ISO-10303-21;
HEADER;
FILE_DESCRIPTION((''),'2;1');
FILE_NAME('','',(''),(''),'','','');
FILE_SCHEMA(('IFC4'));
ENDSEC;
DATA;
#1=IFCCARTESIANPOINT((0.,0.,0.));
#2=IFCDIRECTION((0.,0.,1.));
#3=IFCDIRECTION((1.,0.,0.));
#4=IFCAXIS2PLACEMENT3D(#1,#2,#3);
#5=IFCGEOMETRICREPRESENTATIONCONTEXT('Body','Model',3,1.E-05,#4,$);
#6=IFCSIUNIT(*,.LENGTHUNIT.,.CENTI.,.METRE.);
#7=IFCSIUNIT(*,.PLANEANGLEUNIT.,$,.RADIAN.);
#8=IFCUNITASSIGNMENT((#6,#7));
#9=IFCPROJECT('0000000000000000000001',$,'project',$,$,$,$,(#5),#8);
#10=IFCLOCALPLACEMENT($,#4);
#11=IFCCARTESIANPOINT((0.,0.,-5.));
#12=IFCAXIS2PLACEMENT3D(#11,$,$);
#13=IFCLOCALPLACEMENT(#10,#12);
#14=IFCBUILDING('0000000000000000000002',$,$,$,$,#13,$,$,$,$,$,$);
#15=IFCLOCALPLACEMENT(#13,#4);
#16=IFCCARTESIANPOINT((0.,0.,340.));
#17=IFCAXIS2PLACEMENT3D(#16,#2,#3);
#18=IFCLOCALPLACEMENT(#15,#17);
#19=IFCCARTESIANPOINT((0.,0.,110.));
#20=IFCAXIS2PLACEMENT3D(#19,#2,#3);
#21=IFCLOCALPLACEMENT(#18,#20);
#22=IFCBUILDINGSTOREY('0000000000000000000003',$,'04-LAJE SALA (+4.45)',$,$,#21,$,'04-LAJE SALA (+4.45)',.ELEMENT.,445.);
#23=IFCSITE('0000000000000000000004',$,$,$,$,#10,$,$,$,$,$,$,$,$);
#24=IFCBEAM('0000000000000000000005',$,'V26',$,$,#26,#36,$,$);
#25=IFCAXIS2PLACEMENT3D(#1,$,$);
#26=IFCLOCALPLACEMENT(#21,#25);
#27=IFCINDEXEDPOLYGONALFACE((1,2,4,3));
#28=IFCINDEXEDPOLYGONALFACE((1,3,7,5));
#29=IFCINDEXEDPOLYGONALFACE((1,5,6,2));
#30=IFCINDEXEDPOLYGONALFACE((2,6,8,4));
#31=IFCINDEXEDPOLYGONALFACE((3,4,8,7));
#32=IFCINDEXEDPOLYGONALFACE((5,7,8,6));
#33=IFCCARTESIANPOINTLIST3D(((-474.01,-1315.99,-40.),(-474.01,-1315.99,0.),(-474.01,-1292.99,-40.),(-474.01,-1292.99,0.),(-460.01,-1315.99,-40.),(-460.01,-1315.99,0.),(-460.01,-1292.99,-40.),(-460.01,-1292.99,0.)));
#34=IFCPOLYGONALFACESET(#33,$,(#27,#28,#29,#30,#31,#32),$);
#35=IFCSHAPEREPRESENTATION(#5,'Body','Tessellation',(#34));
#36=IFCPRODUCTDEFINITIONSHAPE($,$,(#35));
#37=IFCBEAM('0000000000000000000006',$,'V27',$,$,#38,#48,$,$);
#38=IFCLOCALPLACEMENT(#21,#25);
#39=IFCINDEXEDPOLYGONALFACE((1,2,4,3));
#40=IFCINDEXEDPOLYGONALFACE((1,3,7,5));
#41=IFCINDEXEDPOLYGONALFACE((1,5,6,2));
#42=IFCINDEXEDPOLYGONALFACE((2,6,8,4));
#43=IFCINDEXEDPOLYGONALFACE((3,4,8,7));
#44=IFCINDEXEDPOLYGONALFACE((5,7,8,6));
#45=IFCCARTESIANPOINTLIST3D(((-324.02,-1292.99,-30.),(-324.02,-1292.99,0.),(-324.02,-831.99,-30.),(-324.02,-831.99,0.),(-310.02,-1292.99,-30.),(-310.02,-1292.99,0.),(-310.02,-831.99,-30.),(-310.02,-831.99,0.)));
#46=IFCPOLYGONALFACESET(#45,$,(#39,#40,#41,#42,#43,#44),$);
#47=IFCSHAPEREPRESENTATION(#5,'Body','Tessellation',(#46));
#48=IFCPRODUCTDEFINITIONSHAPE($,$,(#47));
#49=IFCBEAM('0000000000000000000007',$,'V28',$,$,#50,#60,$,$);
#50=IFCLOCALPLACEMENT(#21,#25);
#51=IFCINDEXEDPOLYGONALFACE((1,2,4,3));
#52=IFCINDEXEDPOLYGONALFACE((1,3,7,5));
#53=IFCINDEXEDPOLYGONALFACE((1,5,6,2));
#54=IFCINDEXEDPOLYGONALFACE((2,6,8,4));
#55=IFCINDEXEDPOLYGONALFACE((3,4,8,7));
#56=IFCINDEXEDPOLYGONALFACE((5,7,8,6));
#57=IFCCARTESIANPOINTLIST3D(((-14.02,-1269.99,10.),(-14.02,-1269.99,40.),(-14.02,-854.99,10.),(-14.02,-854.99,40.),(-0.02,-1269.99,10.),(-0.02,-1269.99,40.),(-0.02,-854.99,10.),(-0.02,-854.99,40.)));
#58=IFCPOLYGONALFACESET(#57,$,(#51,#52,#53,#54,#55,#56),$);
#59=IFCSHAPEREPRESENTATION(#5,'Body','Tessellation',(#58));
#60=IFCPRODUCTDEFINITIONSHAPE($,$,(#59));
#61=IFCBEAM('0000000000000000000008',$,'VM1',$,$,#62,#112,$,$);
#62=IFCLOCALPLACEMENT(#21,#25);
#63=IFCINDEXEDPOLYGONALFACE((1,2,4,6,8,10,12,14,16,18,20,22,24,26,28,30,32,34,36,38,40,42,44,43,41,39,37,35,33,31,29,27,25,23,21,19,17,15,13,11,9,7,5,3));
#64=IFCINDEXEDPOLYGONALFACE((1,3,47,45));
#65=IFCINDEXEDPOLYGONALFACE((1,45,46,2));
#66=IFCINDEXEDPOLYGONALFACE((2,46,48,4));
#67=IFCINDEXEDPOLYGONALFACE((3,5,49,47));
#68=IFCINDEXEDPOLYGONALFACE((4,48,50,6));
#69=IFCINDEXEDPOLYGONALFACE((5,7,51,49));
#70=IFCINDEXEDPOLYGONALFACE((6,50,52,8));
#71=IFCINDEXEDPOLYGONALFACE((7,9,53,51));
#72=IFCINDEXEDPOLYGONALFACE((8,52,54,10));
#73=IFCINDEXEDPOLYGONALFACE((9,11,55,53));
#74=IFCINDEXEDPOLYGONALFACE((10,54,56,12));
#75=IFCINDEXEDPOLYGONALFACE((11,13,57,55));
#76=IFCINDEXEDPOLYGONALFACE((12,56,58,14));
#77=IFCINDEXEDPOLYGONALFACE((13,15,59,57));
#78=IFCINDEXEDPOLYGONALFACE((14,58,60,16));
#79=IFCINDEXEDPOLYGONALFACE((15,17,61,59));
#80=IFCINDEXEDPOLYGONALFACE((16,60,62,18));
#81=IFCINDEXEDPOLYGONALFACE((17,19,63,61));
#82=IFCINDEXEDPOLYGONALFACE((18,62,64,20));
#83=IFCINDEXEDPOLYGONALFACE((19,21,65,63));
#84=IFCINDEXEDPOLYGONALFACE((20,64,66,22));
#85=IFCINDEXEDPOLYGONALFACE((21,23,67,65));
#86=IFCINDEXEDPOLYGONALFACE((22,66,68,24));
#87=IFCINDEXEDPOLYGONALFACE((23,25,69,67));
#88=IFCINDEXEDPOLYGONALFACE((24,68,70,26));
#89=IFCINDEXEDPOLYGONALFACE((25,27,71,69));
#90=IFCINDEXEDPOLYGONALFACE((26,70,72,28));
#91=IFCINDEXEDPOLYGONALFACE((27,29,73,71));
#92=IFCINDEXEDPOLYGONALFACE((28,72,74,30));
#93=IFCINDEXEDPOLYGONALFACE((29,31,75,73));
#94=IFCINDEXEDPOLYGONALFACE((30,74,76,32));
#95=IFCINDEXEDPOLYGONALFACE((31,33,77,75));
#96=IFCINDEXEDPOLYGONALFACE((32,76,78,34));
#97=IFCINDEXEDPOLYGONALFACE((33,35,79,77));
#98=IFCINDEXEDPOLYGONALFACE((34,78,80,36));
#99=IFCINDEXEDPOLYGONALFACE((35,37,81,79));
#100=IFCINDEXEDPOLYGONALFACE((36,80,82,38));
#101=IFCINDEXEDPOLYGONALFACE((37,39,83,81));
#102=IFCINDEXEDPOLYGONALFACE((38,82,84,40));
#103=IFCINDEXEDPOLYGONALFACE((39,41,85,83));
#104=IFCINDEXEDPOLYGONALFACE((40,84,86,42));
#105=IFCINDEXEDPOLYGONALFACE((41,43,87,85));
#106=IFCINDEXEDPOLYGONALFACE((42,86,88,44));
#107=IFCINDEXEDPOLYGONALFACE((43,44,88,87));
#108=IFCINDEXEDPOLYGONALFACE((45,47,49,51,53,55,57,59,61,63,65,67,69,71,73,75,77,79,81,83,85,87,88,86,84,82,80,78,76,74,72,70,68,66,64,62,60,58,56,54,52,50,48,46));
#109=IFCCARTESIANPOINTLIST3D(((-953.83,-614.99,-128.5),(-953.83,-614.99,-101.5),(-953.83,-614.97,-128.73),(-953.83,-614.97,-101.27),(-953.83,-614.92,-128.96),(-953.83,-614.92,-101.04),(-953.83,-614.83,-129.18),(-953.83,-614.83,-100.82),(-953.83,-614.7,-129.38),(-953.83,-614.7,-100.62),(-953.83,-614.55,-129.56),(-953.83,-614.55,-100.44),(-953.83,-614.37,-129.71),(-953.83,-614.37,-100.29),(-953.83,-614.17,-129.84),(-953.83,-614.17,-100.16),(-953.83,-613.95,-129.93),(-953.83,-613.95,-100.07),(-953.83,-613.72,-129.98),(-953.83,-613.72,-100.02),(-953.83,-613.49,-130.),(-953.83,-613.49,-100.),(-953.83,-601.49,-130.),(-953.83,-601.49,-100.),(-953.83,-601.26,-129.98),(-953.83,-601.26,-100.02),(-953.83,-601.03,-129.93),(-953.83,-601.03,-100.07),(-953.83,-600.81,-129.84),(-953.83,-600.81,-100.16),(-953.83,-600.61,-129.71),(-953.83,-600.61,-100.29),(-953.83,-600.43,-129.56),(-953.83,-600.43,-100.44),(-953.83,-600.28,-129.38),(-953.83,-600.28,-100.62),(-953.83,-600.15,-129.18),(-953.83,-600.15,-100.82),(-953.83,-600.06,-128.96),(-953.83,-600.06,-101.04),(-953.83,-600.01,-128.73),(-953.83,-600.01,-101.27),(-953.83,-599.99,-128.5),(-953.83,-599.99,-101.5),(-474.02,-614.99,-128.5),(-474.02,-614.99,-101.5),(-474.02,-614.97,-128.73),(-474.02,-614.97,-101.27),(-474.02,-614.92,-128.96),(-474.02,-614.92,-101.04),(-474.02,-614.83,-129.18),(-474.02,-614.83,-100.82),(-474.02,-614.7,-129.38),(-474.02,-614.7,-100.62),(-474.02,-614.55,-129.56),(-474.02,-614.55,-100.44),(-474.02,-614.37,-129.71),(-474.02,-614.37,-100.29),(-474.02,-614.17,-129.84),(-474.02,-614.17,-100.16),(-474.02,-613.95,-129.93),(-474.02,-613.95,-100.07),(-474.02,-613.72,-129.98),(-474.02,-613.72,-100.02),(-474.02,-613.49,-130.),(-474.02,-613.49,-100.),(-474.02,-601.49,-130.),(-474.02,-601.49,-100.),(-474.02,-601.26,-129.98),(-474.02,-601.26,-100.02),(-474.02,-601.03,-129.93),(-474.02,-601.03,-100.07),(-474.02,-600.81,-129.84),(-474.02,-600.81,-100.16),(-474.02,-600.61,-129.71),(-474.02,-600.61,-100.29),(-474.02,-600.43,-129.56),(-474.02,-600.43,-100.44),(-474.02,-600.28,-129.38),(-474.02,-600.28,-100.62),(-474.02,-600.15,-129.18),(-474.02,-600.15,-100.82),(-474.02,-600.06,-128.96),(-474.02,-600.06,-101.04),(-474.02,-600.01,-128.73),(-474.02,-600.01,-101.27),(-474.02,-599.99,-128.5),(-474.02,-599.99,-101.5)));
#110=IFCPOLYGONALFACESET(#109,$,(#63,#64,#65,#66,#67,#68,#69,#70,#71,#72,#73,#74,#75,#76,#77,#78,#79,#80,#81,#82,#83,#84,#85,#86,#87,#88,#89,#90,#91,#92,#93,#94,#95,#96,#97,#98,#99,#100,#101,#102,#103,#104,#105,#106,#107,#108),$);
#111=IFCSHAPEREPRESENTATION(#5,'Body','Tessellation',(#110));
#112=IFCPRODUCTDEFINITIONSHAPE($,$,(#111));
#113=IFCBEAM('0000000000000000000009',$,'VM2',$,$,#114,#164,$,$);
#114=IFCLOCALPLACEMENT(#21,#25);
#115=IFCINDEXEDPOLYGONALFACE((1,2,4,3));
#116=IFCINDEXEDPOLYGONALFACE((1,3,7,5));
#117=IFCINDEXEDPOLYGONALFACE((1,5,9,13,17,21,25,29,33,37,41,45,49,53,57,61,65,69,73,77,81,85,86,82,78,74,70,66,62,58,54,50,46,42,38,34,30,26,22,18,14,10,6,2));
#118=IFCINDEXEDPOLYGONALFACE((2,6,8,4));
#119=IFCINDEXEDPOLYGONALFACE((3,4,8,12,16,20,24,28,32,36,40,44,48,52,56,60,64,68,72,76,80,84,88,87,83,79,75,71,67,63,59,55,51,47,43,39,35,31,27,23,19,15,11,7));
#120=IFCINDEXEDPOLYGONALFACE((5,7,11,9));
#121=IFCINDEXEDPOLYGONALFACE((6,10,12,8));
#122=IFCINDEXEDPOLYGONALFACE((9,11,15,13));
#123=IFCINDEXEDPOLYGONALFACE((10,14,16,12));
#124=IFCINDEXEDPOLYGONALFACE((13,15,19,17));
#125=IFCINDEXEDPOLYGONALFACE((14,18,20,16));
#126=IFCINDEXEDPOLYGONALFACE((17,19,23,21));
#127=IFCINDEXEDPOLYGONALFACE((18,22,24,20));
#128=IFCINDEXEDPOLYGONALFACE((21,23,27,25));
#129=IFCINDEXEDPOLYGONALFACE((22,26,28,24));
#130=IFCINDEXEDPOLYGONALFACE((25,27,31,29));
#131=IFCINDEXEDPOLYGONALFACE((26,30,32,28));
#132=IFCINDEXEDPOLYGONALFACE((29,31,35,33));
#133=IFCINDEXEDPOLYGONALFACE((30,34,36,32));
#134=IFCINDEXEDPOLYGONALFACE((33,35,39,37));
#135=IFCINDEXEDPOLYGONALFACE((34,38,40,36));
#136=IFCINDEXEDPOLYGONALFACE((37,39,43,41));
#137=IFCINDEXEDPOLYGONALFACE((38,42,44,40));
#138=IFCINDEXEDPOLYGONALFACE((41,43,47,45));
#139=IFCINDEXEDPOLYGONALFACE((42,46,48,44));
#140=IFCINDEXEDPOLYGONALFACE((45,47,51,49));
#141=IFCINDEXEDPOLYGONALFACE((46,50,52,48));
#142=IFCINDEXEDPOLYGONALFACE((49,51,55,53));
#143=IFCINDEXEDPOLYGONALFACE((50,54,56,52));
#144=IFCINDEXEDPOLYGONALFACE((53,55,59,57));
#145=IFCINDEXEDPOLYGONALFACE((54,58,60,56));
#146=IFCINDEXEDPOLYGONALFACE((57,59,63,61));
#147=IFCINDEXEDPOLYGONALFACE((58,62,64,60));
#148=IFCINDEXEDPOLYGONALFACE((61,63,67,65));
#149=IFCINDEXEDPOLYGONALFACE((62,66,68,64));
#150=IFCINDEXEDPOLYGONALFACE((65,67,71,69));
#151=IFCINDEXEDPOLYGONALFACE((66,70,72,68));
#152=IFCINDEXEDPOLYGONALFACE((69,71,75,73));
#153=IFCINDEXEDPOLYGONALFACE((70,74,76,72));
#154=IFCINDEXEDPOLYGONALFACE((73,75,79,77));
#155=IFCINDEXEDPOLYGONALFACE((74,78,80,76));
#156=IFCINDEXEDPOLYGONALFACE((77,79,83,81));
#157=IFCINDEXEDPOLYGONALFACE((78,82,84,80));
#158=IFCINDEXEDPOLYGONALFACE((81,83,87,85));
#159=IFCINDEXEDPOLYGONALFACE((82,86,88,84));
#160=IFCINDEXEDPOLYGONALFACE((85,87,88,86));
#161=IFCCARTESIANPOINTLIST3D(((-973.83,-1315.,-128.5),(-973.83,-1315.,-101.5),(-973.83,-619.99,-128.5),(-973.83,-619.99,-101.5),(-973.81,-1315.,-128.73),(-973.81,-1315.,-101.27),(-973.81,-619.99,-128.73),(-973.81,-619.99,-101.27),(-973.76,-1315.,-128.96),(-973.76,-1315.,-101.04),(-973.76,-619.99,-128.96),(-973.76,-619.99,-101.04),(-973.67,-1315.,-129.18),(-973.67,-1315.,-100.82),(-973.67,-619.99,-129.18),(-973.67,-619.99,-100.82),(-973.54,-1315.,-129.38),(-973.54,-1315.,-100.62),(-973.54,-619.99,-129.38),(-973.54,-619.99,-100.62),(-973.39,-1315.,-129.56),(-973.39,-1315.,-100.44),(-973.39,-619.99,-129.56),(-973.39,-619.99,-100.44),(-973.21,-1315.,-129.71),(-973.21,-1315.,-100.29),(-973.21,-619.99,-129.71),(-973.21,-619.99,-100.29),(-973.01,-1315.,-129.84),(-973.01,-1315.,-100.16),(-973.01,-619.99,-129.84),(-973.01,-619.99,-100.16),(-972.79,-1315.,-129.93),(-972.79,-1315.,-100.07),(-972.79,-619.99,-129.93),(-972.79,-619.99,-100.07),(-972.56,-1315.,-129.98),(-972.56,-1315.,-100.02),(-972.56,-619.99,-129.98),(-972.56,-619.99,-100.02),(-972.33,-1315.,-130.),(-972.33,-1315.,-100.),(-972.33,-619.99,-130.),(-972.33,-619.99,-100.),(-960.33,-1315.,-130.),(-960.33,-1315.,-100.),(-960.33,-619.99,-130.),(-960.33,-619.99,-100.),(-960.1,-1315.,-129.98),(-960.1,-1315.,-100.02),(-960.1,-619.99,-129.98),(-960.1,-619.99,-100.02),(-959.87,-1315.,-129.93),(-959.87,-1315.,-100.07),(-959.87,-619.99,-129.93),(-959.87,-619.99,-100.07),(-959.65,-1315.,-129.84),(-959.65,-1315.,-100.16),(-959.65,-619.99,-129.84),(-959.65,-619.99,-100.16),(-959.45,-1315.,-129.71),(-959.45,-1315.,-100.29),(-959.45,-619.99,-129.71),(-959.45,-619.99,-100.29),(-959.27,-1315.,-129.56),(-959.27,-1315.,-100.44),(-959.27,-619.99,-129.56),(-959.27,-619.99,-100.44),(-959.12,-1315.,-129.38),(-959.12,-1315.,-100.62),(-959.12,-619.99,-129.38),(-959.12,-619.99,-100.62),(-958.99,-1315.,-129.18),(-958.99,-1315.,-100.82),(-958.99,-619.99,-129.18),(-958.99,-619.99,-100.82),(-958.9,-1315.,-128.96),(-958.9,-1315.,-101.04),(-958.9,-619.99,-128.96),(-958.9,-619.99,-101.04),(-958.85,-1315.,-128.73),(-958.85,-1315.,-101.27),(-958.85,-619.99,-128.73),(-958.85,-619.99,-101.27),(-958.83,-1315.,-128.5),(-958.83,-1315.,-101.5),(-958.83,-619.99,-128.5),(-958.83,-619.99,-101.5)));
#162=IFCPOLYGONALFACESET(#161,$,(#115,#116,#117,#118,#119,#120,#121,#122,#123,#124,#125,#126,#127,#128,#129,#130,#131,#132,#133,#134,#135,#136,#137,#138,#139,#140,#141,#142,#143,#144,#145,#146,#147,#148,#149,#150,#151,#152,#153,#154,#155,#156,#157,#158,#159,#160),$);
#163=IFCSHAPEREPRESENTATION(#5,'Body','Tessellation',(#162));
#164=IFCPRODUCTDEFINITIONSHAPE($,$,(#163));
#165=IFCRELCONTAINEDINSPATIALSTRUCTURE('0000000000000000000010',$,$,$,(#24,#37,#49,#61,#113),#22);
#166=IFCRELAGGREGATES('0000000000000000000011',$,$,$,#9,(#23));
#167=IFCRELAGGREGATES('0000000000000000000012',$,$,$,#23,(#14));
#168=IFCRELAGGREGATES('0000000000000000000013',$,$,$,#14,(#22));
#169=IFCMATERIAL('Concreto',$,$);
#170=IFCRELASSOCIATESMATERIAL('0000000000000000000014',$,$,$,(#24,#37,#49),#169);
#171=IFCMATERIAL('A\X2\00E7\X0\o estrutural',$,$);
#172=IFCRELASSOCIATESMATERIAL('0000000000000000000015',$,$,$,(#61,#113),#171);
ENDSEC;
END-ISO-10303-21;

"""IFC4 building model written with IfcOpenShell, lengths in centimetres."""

from ifc_helpers import new_model, si_unit, frame, origin_with_axes, origin_2d_with_axis, place, context, project, spatial, polyline, rectangle, outline, extrude, material, element, save


model = new_model("IFC4")

# Units and contexts
model_context = context("Model", 3, precision=1e-05, world=origin_with_axes(), identifier="Body")
ifc_project = project(units=[si_unit("LENGTHUNIT", "METRE", prefix="CENTI"), si_unit("PLANEANGLEUNIT", "RADIAN")], contexts=[model_context])

# Site, building, storey
site_placement = place(None, origin_with_axes())
site = spatial("IfcSite", under=ifc_project, at=site_placement)
building_placement = place(site_placement, frame((0.0, 0.0, -5.0)))
building = spatial("IfcBuilding", under=site, at=building_placement)
placement_1 = place(building_placement, origin_with_axes())
placement_2 = place(placement_1, frame((0.0, 0.0, 340.0), z_axis=(0.0, 0.0, 1.0), x_axis=(1.0, 0.0, 0.0)))
storey_placement = place(placement_2, frame((0.0, 0.0, 110.0), z_axis=(0.0, 0.0, 1.0), x_axis=(1.0, 0.0, 0.0)))
storey = spatial("IfcBuildingStorey", under=building, at=storey_placement, Name="04-LAJE SALA (+4.45)", LongName="04-LAJE SALA (+4.45)", CompositionType="ELEMENT", Elevation=445.0)

# Shared definitions
ifc_material_1 = material(Name="Concreto")

# Beams
beam_1_placement = place(storey_placement, frame((-467.01, -1304.49, 0.0), z_axis=(0.0, 0.0, 1.0), x_axis=(1.0, 0.0, 0.0)))
element("IfcBeam", 1, at=beam_1_placement, inside=storey, material=ifc_material_1, Name="V26", context=model_context, shape_type="SolidModel", body=[
    extrude(rectangle(XDim=14.0, YDim=40.0, at=origin_2d_with_axis()), frame((0.0, -11.5, -20.0), z_axis=(0.0, 1.0, 0.0), x_axis=(1.0, 0.0, 0.0)), (0.0, 0.0, 1.0), 23.0),
])
beam_2_placement = place(storey_placement, frame((-317.02, -1062.49, 0.0), z_axis=(0.0, 0.0, 1.0), x_axis=(1.0, 0.0, 0.0)))
element("IfcBeam", 2, at=beam_2_placement, inside=storey, material=ifc_material_1, Name="V27", context=model_context, shape_type="SolidModel", body=[
    extrude(rectangle(XDim=14.0, YDim=30.0, at=origin_2d_with_axis()), frame((0.0, -230.5, -15.0), z_axis=(0.0, 1.0, 0.0), x_axis=(1.0, 0.0, 0.0)), (0.0, 0.0, 1.0), 461.0),
])
beam_3_placement = place(storey_placement, frame((-7.02, -1062.49, 40.0), z_axis=(0.0, 0.0, 1.0), x_axis=(1.0, 0.0, 0.0)))
element("IfcBeam", 3, at=beam_3_placement, inside=storey, material=ifc_material_1, Name="V28", context=model_context, shape_type="SolidModel", body=[
    extrude(rectangle(XDim=14.0, YDim=30.0, at=origin_2d_with_axis()), frame((0.0, -207.5, -15.0), z_axis=(0.0, 1.0, 0.0), x_axis=(1.0, 0.0, 0.0)), (0.0, 0.0, 1.0), 415.0),
])
ifc_material_2 = material(Name="Aço estrutural")
beam_4_placement = place(storey_placement, frame((-713.92, -607.49, -100.0), z_axis=(0.0, 0.0, 1.0), x_axis=(1.0, 0.0, 0.0)))
element("IfcBeam", 4, at=beam_4_placement, inside=storey, material=ifc_material_2, Name="VM1", context=model_context, shape_type="SolidModel", body=[
    extrude(outline(polyline([(6.0, -15.0), (6.23, -14.98), (6.46, -14.93), (6.68, -14.84), (6.88, -14.71), (7.06, -14.56), (7.21, -14.38), (7.34, -14.18), (7.43, -13.96), (7.48, -13.73), (7.5, -13.5), (7.5, 13.5), (7.48, 13.73), (7.43, 13.96), (7.34, 14.18), (7.21, 14.38), (7.06, 14.56), (6.88, 14.71), (6.68, 14.84), (6.46, 14.93), (6.23, 14.98), (6.0, 15.0), (-6.0, 15.0), (-6.23, 14.98), (-6.46, 14.93), (-6.68, 14.84), (-6.88, 14.71), (-7.06, 14.56), (-7.21, 14.38), (-7.34, 14.18), (-7.43, 13.96), (-7.48, 13.73), (-7.5, 13.5), (-7.5, -13.5), (-7.48, -13.73), (-7.43, -13.96), (-7.34, -14.18), (-7.21, -14.38), (-7.06, -14.56), (-6.88, -14.71), (-6.68, -14.84), (-6.46, -14.93), (-6.23, -14.98), (-6.0, -15.0), (6.0, -15.0)])), frame((-239.91, 0.0, -15.0), z_axis=(1.0, 0.0, 0.0), x_axis=(0.0, -1.0, 0.0)), (0.0, 0.0, 1.0), 479.81),
])
beam_5_placement = place(storey_placement, frame((-966.33, -967.5, -100.0), z_axis=(0.0, 0.0, 1.0), x_axis=(1.0, 0.0, 0.0)))
element("IfcBeam", 5, at=beam_5_placement, inside=storey, material=ifc_material_2, Name="VM2", context=model_context, shape_type="SolidModel", body=[
    extrude(outline(polyline([(-6.0, 15.0), (-6.23, 14.98), (-6.46, 14.93), (-6.68, 14.84), (-6.88, 14.71), (-7.06, 14.56), (-7.21, 14.38), (-7.34, 14.18), (-7.43, 13.96), (-7.48, 13.73), (-7.5, 13.5), (-7.5, -13.5), (-7.48, -13.73), (-7.43, -13.96), (-7.34, -14.18), (-7.21, -14.38), (-7.06, -14.56), (-6.88, -14.71), (-6.68, -14.84), (-6.46, -14.93), (-6.23, -14.98), (-6.0, -15.0), (6.0, -15.0), (6.23, -14.98), (6.46, -14.93), (6.68, -14.84), (6.88, -14.71), (7.06, -14.56), (7.21, -14.38), (7.34, -14.18), (7.43, -13.96), (7.48, -13.73), (7.5, -13.5), (7.5, 13.5), (7.48, 13.73), (7.43, 13.96), (7.34, 14.18), (7.21, 14.38), (7.06, 14.56), (6.88, 14.71), (6.68, 14.84), (6.46, 14.93), (6.23, 14.98), (6.0, 15.0), (-6.0, 15.0)])), frame((0.0, -347.5, -15.0), z_axis=(0.0, 1.0, 0.0), x_axis=(-1.0, 0.0, 0.0)), (0.0, 0.0, 1.0), 695.01),
])

save(model, "model.ifc")
